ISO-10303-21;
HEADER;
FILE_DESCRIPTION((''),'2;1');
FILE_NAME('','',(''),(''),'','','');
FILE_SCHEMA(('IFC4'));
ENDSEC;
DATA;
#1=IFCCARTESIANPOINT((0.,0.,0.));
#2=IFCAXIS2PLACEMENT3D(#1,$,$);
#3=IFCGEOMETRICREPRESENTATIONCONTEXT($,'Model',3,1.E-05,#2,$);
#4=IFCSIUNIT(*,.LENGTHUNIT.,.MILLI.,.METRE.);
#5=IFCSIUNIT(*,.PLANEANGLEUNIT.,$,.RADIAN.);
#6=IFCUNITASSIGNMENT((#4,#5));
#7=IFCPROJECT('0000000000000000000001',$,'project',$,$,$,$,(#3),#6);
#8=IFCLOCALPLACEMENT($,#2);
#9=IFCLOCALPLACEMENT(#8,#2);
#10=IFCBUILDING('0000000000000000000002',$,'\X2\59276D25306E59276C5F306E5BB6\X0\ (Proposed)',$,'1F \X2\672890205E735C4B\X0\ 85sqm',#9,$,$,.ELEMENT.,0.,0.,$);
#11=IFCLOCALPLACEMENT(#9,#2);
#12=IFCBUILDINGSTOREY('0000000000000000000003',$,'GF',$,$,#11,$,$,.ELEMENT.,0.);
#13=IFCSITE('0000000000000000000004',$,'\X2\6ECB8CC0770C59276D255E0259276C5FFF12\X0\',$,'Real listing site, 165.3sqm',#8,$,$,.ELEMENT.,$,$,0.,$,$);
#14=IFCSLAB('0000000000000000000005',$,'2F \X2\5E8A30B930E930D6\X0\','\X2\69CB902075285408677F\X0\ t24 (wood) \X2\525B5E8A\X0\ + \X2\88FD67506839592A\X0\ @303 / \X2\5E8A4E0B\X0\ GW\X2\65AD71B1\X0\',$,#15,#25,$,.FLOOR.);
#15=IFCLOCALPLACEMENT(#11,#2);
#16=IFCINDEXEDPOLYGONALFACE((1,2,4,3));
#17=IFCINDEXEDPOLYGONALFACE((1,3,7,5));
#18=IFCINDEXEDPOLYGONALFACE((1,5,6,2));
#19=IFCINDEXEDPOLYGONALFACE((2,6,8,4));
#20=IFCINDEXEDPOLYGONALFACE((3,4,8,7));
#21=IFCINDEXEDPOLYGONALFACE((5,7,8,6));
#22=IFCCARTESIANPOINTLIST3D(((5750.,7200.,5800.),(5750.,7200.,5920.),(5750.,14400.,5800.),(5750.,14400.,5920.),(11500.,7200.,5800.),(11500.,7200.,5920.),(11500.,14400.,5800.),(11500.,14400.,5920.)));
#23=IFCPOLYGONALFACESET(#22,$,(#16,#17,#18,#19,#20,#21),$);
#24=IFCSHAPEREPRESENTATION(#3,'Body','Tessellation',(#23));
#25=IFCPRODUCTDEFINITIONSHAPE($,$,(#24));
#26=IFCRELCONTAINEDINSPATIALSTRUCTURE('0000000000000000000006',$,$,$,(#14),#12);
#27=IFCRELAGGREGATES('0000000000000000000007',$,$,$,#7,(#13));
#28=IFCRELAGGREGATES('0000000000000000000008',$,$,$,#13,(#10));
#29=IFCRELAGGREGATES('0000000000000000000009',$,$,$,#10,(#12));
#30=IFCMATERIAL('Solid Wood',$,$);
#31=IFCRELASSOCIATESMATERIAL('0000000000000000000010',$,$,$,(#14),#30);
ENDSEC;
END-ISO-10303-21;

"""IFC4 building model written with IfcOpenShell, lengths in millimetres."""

from ifc_helpers import new_model, si_unit, frame, frame_2d, origin, place, context, project, spatial, rectangle, extrude, material, element, save


model = new_model("IFC4")

# Units and contexts
model_context = context("Model", 3, precision=1e-05, world=origin())
ifc_project = project(units=[si_unit("LENGTHUNIT", "METRE", prefix="MILLI"), si_unit("PLANEANGLEUNIT", "RADIAN")], contexts=[model_context])

# Site, building, storey
site_placement = place(None, origin())
site = spatial("IfcSite", under=ifc_project, at=site_placement, Name="滋賀県大津市大江２", ObjectType="Real listing site, 165.3sqm", CompositionType="ELEMENT", RefElevation=0.0)
building_placement = place(site_placement, origin())
building = spatial("IfcBuilding", under=site, at=building_placement, Name="大津の大江の家 (Proposed)", ObjectType="1F 木造平屋 85sqm", CompositionType="ELEMENT", ElevationOfRefHeight=0.0, ElevationOfTerrain=0.0)
storey_placement = place(building_placement, origin())
storey = spatial("IfcBuildingStorey", under=building, at=storey_placement, Name="GF", CompositionType="ELEMENT", Elevation=0.0)

# Slab
ifc_material_1 = material(Name="Solid Wood")
slab_placement = place(storey_placement, frame((2875.0, 3600.0, 2900.0)))
element("IfcSlab", 1, at=slab_placement, inside=storey, material=ifc_material_1, Name="2F 床スラブ", Description="構造用合板 t24 (wood) 剛床 + 製材根太 @303 / 床下 GW断熱", PredefinedType="FLOOR", context=model_context, shape_type="SweptSolid", body=[
    extrude(rectangle(XDim=5750.0, YDim=7200.0, at=frame_2d((2875.0, 3600.0))), frame((2875.0, 3600.0, 2900.0)), (0.0, 0.0, 1.0), 120.0),
])

save(model, "model.ifc")
